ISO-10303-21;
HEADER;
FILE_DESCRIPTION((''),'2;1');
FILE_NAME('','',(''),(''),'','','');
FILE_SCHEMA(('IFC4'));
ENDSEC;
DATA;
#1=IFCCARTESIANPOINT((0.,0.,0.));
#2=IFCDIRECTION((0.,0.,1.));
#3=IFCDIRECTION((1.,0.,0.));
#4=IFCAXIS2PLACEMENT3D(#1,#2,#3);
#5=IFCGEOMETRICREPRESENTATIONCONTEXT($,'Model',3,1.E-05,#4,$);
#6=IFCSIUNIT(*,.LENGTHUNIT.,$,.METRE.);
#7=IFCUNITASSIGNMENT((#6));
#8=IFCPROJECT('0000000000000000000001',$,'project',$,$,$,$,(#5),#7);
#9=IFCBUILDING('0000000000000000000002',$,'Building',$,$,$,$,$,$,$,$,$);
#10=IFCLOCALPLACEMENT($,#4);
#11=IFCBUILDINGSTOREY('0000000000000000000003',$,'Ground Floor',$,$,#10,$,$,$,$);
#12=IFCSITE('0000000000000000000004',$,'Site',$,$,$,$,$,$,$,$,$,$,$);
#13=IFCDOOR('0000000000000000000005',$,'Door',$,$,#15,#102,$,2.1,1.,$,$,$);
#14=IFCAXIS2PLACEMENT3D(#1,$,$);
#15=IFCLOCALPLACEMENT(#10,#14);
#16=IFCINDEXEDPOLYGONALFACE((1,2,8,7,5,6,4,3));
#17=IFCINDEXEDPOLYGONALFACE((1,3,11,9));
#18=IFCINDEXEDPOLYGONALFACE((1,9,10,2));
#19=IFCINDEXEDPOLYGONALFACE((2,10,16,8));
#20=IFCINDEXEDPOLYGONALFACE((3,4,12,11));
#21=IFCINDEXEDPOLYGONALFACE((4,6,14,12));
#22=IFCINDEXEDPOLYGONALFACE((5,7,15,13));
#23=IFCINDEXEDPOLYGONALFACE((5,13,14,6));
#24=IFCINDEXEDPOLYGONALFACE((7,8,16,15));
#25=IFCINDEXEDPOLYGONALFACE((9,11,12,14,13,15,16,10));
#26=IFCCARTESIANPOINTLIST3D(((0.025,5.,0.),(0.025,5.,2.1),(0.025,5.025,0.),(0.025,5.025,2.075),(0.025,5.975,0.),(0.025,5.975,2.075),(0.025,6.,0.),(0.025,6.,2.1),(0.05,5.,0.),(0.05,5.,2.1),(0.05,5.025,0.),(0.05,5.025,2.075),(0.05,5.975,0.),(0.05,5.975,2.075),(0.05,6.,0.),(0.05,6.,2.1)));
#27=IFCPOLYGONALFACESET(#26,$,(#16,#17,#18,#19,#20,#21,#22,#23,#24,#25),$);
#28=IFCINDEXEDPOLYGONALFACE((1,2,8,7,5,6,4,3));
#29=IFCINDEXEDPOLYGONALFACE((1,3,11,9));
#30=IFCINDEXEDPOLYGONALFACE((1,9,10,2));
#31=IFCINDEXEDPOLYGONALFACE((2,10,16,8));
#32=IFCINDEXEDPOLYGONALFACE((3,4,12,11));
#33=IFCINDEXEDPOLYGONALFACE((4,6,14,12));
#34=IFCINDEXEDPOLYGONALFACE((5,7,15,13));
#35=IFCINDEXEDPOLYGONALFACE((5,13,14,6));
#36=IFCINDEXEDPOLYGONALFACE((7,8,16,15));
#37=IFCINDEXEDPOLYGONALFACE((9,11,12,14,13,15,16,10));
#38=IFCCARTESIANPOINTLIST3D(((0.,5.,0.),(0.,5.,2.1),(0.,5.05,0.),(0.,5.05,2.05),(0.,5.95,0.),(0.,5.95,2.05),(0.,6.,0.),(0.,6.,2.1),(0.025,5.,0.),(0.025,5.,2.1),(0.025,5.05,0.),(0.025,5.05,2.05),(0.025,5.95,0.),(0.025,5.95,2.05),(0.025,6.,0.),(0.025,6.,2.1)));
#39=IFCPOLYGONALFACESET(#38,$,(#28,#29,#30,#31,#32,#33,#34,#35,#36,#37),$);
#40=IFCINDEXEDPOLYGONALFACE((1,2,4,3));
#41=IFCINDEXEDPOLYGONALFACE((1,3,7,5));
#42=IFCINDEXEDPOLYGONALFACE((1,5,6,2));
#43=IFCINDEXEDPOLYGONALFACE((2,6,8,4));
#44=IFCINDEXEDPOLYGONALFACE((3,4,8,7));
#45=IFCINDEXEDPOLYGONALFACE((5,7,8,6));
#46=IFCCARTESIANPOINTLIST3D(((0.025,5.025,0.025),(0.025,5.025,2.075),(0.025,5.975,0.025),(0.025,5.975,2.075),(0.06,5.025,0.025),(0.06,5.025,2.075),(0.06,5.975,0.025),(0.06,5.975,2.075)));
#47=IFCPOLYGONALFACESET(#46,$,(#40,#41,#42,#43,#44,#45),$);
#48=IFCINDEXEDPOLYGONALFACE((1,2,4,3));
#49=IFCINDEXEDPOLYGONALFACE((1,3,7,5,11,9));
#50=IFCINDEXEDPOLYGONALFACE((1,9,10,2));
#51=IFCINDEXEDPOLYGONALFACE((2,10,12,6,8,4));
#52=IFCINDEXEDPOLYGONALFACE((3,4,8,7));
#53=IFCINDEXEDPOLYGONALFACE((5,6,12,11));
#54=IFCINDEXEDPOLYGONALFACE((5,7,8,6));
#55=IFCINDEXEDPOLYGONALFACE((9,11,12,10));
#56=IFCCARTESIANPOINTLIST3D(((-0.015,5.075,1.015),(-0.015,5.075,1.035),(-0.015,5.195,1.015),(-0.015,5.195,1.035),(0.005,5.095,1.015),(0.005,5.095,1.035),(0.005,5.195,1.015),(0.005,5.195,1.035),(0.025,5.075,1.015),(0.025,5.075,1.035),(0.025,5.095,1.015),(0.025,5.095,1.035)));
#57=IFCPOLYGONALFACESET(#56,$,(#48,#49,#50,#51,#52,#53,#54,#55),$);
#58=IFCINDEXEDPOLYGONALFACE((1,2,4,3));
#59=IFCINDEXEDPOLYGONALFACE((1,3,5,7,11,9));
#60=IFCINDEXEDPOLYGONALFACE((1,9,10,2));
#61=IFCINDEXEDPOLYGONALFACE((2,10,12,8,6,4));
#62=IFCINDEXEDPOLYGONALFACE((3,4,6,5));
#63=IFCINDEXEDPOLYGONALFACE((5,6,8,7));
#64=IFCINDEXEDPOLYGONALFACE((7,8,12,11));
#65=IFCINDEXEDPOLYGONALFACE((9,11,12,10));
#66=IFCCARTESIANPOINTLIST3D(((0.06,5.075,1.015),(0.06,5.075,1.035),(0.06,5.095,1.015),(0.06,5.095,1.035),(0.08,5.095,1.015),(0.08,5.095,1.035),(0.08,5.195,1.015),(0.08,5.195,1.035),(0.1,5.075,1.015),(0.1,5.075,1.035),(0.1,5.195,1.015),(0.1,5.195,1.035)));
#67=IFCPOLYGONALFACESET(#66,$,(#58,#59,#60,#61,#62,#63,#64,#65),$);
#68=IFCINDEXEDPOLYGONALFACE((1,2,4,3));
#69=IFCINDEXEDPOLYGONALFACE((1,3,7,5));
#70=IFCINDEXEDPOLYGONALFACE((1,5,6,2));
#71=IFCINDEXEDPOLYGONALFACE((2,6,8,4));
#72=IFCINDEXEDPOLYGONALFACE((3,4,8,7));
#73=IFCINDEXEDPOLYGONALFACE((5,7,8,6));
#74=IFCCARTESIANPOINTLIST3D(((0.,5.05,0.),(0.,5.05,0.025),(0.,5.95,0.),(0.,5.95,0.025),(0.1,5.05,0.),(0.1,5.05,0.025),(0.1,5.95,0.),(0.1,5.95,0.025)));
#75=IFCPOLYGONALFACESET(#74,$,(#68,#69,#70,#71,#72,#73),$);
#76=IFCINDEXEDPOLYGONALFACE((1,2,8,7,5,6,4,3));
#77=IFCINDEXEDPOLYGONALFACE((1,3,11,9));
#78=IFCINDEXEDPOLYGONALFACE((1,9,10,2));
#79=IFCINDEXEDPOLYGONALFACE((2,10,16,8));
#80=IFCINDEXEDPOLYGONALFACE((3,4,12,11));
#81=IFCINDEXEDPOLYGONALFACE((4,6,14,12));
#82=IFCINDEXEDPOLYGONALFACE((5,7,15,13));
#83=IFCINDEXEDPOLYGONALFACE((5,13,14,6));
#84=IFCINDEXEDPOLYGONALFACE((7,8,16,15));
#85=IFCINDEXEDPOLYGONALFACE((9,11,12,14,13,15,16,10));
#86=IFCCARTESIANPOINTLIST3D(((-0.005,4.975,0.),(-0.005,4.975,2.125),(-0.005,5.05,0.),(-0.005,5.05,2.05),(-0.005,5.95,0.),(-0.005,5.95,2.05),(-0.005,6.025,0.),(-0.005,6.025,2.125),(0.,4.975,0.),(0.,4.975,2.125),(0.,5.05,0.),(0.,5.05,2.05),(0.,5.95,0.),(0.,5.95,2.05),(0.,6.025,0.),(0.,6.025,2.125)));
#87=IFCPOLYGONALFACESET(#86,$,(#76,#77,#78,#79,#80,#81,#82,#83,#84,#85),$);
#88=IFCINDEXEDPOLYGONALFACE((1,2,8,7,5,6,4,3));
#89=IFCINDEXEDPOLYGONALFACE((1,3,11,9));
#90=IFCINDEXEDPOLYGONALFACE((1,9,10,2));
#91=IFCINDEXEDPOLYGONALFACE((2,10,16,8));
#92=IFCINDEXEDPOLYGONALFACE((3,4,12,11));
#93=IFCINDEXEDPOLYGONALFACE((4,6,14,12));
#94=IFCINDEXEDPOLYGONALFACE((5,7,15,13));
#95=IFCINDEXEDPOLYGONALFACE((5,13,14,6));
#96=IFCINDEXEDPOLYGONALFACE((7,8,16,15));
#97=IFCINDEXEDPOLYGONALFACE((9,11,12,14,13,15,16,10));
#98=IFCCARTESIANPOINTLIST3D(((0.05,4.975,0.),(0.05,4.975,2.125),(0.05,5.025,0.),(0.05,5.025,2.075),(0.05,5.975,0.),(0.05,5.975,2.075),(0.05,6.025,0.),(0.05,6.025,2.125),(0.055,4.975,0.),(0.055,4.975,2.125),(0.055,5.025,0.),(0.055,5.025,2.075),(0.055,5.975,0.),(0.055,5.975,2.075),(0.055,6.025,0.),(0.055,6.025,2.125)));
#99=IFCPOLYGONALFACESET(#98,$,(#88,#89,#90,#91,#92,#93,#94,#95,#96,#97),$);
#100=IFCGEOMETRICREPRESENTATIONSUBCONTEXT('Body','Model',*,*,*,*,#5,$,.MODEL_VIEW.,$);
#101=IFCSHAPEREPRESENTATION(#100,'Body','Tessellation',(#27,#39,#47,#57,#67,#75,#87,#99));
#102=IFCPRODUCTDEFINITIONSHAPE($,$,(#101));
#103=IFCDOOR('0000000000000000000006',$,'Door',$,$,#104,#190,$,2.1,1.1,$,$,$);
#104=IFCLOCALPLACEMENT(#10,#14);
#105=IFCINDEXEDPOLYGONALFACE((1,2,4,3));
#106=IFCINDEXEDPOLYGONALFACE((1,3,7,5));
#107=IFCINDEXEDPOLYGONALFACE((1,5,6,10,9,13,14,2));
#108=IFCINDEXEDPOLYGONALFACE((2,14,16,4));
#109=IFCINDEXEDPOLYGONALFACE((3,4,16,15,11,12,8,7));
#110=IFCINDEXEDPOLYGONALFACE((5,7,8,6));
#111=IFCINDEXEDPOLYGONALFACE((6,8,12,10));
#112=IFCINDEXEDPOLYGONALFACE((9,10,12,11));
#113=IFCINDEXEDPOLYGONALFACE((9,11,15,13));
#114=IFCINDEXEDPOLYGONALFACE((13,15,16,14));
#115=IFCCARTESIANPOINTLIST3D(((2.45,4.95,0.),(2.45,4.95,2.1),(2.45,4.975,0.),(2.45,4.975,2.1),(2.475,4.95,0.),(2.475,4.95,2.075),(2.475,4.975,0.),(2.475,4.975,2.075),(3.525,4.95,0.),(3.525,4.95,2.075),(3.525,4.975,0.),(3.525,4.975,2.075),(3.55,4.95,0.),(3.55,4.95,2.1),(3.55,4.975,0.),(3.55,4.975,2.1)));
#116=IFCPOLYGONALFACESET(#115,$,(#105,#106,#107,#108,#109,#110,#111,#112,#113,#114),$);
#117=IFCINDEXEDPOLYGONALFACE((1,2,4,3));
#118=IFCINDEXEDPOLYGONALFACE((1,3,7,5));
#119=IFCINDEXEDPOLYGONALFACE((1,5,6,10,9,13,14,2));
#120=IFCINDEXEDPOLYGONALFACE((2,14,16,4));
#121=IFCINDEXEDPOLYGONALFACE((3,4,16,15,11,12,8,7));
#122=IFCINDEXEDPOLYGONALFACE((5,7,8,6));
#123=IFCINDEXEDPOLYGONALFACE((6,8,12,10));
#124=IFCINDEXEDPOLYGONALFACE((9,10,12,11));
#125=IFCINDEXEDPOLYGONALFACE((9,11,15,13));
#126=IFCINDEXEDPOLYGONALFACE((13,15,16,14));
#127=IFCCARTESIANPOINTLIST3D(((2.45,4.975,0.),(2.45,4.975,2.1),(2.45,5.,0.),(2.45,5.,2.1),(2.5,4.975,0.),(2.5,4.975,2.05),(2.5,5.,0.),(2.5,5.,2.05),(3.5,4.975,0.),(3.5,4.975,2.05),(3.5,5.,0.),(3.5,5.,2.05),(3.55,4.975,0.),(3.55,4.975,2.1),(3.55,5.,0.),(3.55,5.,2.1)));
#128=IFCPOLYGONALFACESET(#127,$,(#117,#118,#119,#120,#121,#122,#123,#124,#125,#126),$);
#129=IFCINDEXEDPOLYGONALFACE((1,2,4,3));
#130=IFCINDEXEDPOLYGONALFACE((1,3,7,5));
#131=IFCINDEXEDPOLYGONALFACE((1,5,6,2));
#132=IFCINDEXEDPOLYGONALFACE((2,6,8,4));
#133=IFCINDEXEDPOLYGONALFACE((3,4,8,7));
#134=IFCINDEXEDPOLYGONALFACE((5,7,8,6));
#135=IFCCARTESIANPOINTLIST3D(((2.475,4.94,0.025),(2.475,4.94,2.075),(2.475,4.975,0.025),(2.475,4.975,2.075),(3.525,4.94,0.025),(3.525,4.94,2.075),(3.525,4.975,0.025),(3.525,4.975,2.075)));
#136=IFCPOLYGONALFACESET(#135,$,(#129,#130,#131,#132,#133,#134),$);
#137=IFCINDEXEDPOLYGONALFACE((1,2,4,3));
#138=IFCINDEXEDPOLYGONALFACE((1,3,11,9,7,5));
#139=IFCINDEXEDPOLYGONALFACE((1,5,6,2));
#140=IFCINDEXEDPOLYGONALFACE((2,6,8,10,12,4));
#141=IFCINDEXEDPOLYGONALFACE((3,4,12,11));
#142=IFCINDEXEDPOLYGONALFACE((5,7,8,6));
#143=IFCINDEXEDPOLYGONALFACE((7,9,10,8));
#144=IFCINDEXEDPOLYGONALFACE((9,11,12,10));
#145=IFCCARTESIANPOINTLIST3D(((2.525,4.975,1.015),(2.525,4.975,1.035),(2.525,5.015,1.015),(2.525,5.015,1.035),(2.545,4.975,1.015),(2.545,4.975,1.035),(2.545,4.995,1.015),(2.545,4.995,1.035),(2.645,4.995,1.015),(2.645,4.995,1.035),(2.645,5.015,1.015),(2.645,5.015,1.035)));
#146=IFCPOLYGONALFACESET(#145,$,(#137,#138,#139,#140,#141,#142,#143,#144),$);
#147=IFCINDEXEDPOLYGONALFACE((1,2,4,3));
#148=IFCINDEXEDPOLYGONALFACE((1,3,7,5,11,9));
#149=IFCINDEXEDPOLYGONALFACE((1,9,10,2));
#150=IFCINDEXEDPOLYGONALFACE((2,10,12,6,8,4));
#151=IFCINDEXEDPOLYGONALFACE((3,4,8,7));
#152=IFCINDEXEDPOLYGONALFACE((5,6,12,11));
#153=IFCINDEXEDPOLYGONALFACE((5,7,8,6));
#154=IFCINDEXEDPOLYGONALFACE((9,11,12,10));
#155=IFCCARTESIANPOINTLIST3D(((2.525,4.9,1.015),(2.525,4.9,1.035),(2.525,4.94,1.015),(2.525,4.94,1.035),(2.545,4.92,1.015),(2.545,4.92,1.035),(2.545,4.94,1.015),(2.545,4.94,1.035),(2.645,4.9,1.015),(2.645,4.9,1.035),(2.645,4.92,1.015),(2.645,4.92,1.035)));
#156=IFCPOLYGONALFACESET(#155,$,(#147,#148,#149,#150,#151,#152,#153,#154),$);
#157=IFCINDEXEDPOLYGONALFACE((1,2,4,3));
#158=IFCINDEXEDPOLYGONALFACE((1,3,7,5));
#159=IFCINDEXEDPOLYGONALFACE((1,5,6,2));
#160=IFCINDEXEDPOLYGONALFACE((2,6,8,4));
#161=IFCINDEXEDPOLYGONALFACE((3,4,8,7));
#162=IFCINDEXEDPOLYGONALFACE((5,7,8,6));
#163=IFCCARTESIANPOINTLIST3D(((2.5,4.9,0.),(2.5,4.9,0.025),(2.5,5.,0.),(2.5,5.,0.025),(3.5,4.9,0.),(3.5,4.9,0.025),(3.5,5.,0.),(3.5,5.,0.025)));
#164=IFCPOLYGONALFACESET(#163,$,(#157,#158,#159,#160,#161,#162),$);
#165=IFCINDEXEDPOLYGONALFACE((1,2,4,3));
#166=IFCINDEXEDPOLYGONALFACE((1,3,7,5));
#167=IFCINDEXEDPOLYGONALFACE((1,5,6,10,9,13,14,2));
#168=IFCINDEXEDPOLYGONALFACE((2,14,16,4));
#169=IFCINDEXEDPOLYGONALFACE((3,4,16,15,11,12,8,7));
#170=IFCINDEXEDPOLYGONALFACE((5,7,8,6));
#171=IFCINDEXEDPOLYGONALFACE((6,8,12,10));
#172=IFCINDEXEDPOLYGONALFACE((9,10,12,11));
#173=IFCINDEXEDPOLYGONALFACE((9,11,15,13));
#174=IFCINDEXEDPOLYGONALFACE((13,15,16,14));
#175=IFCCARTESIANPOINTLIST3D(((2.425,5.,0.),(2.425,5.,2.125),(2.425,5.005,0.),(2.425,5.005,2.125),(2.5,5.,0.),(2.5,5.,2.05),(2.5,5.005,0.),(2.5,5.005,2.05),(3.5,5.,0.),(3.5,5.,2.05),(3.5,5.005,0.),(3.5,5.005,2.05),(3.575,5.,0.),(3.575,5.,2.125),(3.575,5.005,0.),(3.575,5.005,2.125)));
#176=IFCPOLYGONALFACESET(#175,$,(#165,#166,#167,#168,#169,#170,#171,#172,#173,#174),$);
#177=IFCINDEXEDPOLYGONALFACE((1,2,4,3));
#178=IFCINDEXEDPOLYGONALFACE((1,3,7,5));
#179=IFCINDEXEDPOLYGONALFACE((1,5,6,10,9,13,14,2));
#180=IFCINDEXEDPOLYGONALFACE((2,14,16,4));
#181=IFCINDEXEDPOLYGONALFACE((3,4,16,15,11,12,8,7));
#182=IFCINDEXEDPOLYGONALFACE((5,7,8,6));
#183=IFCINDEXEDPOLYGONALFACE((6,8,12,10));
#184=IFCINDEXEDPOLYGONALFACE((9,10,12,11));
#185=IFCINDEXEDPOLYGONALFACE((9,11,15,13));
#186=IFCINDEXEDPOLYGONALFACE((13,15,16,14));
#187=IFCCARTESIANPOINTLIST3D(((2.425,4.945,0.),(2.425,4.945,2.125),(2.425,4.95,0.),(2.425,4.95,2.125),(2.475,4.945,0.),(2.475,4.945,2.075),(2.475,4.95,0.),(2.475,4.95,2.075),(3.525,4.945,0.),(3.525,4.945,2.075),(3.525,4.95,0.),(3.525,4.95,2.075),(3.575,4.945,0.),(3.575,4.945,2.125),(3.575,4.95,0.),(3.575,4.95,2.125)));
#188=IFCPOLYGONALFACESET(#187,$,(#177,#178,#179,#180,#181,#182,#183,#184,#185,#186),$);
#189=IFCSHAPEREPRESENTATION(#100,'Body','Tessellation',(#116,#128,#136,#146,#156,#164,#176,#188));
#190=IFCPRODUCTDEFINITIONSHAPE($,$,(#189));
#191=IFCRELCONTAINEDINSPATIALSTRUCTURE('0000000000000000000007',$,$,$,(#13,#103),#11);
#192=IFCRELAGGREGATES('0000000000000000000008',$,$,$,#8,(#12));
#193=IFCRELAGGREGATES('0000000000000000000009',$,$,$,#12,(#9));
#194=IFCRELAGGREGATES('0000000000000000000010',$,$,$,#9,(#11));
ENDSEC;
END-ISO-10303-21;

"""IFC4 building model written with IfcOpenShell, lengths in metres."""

from ifc_helpers import new_model, si_unit, frame, origin_with_axes, place, context, subcontext, project, spatial, line, indexed_curve, outline, extrude, element, save


model = new_model("IFC4")

# Units and contexts
model_context = context("Model", 3, precision=1e-05, world=origin_with_axes())
body_context = subcontext(model_context, "Body", "Model", "MODEL_VIEW")
ifc_project = project(units=[si_unit("LENGTHUNIT", "METRE")], contexts=[model_context])

# Site, building, storey
site = spatial("IfcSite", under=ifc_project, Name="Site")
building = spatial("IfcBuilding", under=site, Name="Building")
storey_placement = place(None, origin_with_axes())
storey = spatial("IfcBuildingStorey", under=building, at=storey_placement, Name="Ground Floor")

# Doors
door_1_placement = place(storey_placement, frame((0.0, 6.0, 0.0), z_axis=(0.0, 0.0, 1.0), x_axis=(0.0, -1.0, 0.0)))
element("IfcDoor", 1, at=door_1_placement, inside=storey, Name="Door", OverallHeight=2.1, OverallWidth=1.0, context=body_context, shape_type="SweptSolid", body=[
    extrude(outline(indexed_curve([(0.0, 0.0), (0.0, 2.1), (1.0, 2.1), (1.0, 0.0), (0.975, 0.0), (0.975, 2.075), (0.025, 2.075), (0.025, 0.0)], segments=[line(1, 2, 3, 4, 5, 6, 7, 8, 1)])), frame((0.0, 0.025, 0.0), z_axis=(0.0, -1.0, 0.0), x_axis=(1.0, 0.0, 0.0)), (0.0, 0.0, -1.0), 0.025),
    extrude(outline(indexed_curve([(0.0, 0.0), (0.0, 2.1), (1.0, 2.1), (1.0, 0.0), (0.95, 0.0), (0.95, 2.05), (0.05, 2.05), (0.05, 0.0)], segments=[line(1, 2, 3, 4, 5, 6, 7, 8, 1)])), frame((0.0, 0.0, 0.0), z_axis=(0.0, -1.0, 0.0), x_axis=(1.0, 0.0, 0.0)), (0.0, 0.0, -1.0), 0.025),
    extrude(outline(indexed_curve([(0.0, 0.0), (0.95, 0.0), (0.95, 0.035), (0.0, 0.035)], segments=[line(1, 2, 3, 4, 1)])), frame((0.025, 0.025, 0.025), z_axis=(0.0, 0.0, 1.0), x_axis=(1.0, 0.0, 0.0)), (0.0, 0.0, 1.0), 2.05),
    extrude(outline(indexed_curve([(0.0, 0.0), (0.0, -0.04), (-0.12, -0.04), (-0.12, -0.02), (-0.02, -0.02), (-0.02, 0.0)], segments=[line(1, 2, 3, 4, 5, 6, 1)])), frame((0.925, 0.025, 1.015), z_axis=(0.0, 0.0, 1.0), x_axis=(1.0, 0.0, 0.0)), (0.0, 0.0, 1.0), 0.02),
    extrude(outline(indexed_curve([(0.0, 0.0), (0.0, 0.04), (-0.12, 0.04), (-0.12, 0.02), (-0.02, 0.02), (-0.02, 0.0)], segments=[line(1, 2, 3, 4, 5, 6, 1)])), frame((0.925, 0.06, 1.015), z_axis=(0.0, 0.0, 1.0), x_axis=(1.0, 0.0, 0.0)), (0.0, 0.0, 1.0), 0.02),
    extrude(outline(indexed_curve([(0.0, 0.0), (0.9, 0.0), (0.9, 0.1), (0.0, 0.1)], segments=[line(1, 2, 3, 4, 1)])), frame((0.05, 0.0, 0.0), z_axis=(0.0, 0.0, 1.0), x_axis=(1.0, 0.0, 0.0)), (0.0, 0.0, 1.0), 0.025),
    extrude(outline(indexed_curve([(0.0, 0.0), (0.0, 2.125), (1.05, 2.125), (1.05, 0.0), (0.975, 0.0), (0.975, 2.05), (0.075, 2.05), (0.075, 0.0)], segments=[line(1, 2, 3, 4, 5, 6, 7, 8, 1)])), frame((-0.025, -0.005, 0.0), z_axis=(0.0, -1.0, 0.0), x_axis=(1.0, 0.0, 0.0)), (0.0, 0.0, -1.0), 0.005),
    extrude(outline(indexed_curve([(0.0, 0.0), (0.0, 2.125), (1.05, 2.125), (1.05, 0.0), (1.0, 0.0), (1.0, 2.075), (0.05, 2.075), (0.05, 0.0)], segments=[line(1, 2, 3, 4, 5, 6, 7, 8, 1)])), frame((-0.025, 0.05, 0.0), z_axis=(0.0, -1.0, 0.0), x_axis=(1.0, 0.0, 0.0)), (0.0, 0.0, -1.0), 0.005),
])
door_2_placement = place(storey_placement, frame((3.55, 5.0, 0.0), z_axis=(0.0, 0.0, 1.0), x_axis=(-1.0, 0.0, 0.0)))
element("IfcDoor", 2, at=door_2_placement, inside=storey, Name="Door", OverallHeight=2.1, OverallWidth=1.1, context=body_context, shape_type="SweptSolid", body=[
    extrude(outline(indexed_curve([(0.0, 0.0), (0.0, 2.1), (1.1, 2.1), (1.1, 0.0), (1.075, 0.0), (1.075, 2.075), (0.025, 2.075), (0.025, 0.0)], segments=[line(1, 2, 3, 4, 5, 6, 7, 8, 1)])), frame((0.0, 0.025, 0.0), z_axis=(0.0, -1.0, 0.0), x_axis=(1.0, 0.0, 0.0)), (0.0, 0.0, -1.0), 0.025),
    extrude(outline(indexed_curve([(0.0, 0.0), (0.0, 2.1), (1.1, 2.1), (1.1, 0.0), (1.05, 0.0), (1.05, 2.05), (0.05, 2.05), (0.05, 0.0)], segments=[line(1, 2, 3, 4, 5, 6, 7, 8, 1)])), frame((0.0, 0.0, 0.0), z_axis=(0.0, -1.0, 0.0), x_axis=(1.0, 0.0, 0.0)), (0.0, 0.0, -1.0), 0.025),
    extrude(outline(indexed_curve([(0.0, 0.0), (1.05, 0.0), (1.05, 0.035), (0.0, 0.035)], segments=[line(1, 2, 3, 4, 1)])), frame((0.025, 0.025, 0.025), z_axis=(0.0, 0.0, 1.0), x_axis=(1.0, 0.0, 0.0)), (0.0, 0.0, 1.0), 2.05),
    extrude(outline(indexed_curve([(0.0, 0.0), (0.0, -0.04), (-0.12, -0.04), (-0.12, -0.02), (-0.02, -0.02), (-0.02, 0.0)], segments=[line(1, 2, 3, 4, 5, 6, 1)])), frame((1.025, 0.025, 1.015), z_axis=(0.0, 0.0, 1.0), x_axis=(1.0, 0.0, 0.0)), (0.0, 0.0, 1.0), 0.02),
    extrude(outline(indexed_curve([(0.0, 0.0), (0.0, 0.04), (-0.12, 0.04), (-0.12, 0.02), (-0.02, 0.02), (-0.02, 0.0)], segments=[line(1, 2, 3, 4, 5, 6, 1)])), frame((1.025, 0.06, 1.015), z_axis=(0.0, 0.0, 1.0), x_axis=(1.0, 0.0, 0.0)), (0.0, 0.0, 1.0), 0.02),
    extrude(outline(indexed_curve([(0.0, 0.0), (1.0, 0.0), (1.0, 0.1), (0.0, 0.1)], segments=[line(1, 2, 3, 4, 1)])), frame((0.05, 0.0, 0.0), z_axis=(0.0, 0.0, 1.0), x_axis=(1.0, 0.0, 0.0)), (0.0, 0.0, 1.0), 0.025),
    extrude(outline(indexed_curve([(0.0, 0.0), (0.0, 2.125), (1.15, 2.125), (1.15, 0.0), (1.075, 0.0), (1.075, 2.05), (0.075, 2.05), (0.075, 0.0)], segments=[line(1, 2, 3, 4, 5, 6, 7, 8, 1)])), frame((-0.025, -0.005, 0.0), z_axis=(0.0, -1.0, 0.0), x_axis=(1.0, 0.0, 0.0)), (0.0, 0.0, -1.0), 0.005),
    extrude(outline(indexed_curve([(0.0, 0.0), (0.0, 2.125), (1.15, 2.125), (1.15, 0.0), (1.1, 0.0), (1.1, 2.075), (0.05, 2.075), (0.05, 0.0)], segments=[line(1, 2, 3, 4, 5, 6, 7, 8, 1)])), frame((-0.025, 0.05, 0.0), z_axis=(0.0, -1.0, 0.0), x_axis=(1.0, 0.0, 0.0)), (0.0, 0.0, -1.0), 0.005),
])

save(model, "model.ifc")
